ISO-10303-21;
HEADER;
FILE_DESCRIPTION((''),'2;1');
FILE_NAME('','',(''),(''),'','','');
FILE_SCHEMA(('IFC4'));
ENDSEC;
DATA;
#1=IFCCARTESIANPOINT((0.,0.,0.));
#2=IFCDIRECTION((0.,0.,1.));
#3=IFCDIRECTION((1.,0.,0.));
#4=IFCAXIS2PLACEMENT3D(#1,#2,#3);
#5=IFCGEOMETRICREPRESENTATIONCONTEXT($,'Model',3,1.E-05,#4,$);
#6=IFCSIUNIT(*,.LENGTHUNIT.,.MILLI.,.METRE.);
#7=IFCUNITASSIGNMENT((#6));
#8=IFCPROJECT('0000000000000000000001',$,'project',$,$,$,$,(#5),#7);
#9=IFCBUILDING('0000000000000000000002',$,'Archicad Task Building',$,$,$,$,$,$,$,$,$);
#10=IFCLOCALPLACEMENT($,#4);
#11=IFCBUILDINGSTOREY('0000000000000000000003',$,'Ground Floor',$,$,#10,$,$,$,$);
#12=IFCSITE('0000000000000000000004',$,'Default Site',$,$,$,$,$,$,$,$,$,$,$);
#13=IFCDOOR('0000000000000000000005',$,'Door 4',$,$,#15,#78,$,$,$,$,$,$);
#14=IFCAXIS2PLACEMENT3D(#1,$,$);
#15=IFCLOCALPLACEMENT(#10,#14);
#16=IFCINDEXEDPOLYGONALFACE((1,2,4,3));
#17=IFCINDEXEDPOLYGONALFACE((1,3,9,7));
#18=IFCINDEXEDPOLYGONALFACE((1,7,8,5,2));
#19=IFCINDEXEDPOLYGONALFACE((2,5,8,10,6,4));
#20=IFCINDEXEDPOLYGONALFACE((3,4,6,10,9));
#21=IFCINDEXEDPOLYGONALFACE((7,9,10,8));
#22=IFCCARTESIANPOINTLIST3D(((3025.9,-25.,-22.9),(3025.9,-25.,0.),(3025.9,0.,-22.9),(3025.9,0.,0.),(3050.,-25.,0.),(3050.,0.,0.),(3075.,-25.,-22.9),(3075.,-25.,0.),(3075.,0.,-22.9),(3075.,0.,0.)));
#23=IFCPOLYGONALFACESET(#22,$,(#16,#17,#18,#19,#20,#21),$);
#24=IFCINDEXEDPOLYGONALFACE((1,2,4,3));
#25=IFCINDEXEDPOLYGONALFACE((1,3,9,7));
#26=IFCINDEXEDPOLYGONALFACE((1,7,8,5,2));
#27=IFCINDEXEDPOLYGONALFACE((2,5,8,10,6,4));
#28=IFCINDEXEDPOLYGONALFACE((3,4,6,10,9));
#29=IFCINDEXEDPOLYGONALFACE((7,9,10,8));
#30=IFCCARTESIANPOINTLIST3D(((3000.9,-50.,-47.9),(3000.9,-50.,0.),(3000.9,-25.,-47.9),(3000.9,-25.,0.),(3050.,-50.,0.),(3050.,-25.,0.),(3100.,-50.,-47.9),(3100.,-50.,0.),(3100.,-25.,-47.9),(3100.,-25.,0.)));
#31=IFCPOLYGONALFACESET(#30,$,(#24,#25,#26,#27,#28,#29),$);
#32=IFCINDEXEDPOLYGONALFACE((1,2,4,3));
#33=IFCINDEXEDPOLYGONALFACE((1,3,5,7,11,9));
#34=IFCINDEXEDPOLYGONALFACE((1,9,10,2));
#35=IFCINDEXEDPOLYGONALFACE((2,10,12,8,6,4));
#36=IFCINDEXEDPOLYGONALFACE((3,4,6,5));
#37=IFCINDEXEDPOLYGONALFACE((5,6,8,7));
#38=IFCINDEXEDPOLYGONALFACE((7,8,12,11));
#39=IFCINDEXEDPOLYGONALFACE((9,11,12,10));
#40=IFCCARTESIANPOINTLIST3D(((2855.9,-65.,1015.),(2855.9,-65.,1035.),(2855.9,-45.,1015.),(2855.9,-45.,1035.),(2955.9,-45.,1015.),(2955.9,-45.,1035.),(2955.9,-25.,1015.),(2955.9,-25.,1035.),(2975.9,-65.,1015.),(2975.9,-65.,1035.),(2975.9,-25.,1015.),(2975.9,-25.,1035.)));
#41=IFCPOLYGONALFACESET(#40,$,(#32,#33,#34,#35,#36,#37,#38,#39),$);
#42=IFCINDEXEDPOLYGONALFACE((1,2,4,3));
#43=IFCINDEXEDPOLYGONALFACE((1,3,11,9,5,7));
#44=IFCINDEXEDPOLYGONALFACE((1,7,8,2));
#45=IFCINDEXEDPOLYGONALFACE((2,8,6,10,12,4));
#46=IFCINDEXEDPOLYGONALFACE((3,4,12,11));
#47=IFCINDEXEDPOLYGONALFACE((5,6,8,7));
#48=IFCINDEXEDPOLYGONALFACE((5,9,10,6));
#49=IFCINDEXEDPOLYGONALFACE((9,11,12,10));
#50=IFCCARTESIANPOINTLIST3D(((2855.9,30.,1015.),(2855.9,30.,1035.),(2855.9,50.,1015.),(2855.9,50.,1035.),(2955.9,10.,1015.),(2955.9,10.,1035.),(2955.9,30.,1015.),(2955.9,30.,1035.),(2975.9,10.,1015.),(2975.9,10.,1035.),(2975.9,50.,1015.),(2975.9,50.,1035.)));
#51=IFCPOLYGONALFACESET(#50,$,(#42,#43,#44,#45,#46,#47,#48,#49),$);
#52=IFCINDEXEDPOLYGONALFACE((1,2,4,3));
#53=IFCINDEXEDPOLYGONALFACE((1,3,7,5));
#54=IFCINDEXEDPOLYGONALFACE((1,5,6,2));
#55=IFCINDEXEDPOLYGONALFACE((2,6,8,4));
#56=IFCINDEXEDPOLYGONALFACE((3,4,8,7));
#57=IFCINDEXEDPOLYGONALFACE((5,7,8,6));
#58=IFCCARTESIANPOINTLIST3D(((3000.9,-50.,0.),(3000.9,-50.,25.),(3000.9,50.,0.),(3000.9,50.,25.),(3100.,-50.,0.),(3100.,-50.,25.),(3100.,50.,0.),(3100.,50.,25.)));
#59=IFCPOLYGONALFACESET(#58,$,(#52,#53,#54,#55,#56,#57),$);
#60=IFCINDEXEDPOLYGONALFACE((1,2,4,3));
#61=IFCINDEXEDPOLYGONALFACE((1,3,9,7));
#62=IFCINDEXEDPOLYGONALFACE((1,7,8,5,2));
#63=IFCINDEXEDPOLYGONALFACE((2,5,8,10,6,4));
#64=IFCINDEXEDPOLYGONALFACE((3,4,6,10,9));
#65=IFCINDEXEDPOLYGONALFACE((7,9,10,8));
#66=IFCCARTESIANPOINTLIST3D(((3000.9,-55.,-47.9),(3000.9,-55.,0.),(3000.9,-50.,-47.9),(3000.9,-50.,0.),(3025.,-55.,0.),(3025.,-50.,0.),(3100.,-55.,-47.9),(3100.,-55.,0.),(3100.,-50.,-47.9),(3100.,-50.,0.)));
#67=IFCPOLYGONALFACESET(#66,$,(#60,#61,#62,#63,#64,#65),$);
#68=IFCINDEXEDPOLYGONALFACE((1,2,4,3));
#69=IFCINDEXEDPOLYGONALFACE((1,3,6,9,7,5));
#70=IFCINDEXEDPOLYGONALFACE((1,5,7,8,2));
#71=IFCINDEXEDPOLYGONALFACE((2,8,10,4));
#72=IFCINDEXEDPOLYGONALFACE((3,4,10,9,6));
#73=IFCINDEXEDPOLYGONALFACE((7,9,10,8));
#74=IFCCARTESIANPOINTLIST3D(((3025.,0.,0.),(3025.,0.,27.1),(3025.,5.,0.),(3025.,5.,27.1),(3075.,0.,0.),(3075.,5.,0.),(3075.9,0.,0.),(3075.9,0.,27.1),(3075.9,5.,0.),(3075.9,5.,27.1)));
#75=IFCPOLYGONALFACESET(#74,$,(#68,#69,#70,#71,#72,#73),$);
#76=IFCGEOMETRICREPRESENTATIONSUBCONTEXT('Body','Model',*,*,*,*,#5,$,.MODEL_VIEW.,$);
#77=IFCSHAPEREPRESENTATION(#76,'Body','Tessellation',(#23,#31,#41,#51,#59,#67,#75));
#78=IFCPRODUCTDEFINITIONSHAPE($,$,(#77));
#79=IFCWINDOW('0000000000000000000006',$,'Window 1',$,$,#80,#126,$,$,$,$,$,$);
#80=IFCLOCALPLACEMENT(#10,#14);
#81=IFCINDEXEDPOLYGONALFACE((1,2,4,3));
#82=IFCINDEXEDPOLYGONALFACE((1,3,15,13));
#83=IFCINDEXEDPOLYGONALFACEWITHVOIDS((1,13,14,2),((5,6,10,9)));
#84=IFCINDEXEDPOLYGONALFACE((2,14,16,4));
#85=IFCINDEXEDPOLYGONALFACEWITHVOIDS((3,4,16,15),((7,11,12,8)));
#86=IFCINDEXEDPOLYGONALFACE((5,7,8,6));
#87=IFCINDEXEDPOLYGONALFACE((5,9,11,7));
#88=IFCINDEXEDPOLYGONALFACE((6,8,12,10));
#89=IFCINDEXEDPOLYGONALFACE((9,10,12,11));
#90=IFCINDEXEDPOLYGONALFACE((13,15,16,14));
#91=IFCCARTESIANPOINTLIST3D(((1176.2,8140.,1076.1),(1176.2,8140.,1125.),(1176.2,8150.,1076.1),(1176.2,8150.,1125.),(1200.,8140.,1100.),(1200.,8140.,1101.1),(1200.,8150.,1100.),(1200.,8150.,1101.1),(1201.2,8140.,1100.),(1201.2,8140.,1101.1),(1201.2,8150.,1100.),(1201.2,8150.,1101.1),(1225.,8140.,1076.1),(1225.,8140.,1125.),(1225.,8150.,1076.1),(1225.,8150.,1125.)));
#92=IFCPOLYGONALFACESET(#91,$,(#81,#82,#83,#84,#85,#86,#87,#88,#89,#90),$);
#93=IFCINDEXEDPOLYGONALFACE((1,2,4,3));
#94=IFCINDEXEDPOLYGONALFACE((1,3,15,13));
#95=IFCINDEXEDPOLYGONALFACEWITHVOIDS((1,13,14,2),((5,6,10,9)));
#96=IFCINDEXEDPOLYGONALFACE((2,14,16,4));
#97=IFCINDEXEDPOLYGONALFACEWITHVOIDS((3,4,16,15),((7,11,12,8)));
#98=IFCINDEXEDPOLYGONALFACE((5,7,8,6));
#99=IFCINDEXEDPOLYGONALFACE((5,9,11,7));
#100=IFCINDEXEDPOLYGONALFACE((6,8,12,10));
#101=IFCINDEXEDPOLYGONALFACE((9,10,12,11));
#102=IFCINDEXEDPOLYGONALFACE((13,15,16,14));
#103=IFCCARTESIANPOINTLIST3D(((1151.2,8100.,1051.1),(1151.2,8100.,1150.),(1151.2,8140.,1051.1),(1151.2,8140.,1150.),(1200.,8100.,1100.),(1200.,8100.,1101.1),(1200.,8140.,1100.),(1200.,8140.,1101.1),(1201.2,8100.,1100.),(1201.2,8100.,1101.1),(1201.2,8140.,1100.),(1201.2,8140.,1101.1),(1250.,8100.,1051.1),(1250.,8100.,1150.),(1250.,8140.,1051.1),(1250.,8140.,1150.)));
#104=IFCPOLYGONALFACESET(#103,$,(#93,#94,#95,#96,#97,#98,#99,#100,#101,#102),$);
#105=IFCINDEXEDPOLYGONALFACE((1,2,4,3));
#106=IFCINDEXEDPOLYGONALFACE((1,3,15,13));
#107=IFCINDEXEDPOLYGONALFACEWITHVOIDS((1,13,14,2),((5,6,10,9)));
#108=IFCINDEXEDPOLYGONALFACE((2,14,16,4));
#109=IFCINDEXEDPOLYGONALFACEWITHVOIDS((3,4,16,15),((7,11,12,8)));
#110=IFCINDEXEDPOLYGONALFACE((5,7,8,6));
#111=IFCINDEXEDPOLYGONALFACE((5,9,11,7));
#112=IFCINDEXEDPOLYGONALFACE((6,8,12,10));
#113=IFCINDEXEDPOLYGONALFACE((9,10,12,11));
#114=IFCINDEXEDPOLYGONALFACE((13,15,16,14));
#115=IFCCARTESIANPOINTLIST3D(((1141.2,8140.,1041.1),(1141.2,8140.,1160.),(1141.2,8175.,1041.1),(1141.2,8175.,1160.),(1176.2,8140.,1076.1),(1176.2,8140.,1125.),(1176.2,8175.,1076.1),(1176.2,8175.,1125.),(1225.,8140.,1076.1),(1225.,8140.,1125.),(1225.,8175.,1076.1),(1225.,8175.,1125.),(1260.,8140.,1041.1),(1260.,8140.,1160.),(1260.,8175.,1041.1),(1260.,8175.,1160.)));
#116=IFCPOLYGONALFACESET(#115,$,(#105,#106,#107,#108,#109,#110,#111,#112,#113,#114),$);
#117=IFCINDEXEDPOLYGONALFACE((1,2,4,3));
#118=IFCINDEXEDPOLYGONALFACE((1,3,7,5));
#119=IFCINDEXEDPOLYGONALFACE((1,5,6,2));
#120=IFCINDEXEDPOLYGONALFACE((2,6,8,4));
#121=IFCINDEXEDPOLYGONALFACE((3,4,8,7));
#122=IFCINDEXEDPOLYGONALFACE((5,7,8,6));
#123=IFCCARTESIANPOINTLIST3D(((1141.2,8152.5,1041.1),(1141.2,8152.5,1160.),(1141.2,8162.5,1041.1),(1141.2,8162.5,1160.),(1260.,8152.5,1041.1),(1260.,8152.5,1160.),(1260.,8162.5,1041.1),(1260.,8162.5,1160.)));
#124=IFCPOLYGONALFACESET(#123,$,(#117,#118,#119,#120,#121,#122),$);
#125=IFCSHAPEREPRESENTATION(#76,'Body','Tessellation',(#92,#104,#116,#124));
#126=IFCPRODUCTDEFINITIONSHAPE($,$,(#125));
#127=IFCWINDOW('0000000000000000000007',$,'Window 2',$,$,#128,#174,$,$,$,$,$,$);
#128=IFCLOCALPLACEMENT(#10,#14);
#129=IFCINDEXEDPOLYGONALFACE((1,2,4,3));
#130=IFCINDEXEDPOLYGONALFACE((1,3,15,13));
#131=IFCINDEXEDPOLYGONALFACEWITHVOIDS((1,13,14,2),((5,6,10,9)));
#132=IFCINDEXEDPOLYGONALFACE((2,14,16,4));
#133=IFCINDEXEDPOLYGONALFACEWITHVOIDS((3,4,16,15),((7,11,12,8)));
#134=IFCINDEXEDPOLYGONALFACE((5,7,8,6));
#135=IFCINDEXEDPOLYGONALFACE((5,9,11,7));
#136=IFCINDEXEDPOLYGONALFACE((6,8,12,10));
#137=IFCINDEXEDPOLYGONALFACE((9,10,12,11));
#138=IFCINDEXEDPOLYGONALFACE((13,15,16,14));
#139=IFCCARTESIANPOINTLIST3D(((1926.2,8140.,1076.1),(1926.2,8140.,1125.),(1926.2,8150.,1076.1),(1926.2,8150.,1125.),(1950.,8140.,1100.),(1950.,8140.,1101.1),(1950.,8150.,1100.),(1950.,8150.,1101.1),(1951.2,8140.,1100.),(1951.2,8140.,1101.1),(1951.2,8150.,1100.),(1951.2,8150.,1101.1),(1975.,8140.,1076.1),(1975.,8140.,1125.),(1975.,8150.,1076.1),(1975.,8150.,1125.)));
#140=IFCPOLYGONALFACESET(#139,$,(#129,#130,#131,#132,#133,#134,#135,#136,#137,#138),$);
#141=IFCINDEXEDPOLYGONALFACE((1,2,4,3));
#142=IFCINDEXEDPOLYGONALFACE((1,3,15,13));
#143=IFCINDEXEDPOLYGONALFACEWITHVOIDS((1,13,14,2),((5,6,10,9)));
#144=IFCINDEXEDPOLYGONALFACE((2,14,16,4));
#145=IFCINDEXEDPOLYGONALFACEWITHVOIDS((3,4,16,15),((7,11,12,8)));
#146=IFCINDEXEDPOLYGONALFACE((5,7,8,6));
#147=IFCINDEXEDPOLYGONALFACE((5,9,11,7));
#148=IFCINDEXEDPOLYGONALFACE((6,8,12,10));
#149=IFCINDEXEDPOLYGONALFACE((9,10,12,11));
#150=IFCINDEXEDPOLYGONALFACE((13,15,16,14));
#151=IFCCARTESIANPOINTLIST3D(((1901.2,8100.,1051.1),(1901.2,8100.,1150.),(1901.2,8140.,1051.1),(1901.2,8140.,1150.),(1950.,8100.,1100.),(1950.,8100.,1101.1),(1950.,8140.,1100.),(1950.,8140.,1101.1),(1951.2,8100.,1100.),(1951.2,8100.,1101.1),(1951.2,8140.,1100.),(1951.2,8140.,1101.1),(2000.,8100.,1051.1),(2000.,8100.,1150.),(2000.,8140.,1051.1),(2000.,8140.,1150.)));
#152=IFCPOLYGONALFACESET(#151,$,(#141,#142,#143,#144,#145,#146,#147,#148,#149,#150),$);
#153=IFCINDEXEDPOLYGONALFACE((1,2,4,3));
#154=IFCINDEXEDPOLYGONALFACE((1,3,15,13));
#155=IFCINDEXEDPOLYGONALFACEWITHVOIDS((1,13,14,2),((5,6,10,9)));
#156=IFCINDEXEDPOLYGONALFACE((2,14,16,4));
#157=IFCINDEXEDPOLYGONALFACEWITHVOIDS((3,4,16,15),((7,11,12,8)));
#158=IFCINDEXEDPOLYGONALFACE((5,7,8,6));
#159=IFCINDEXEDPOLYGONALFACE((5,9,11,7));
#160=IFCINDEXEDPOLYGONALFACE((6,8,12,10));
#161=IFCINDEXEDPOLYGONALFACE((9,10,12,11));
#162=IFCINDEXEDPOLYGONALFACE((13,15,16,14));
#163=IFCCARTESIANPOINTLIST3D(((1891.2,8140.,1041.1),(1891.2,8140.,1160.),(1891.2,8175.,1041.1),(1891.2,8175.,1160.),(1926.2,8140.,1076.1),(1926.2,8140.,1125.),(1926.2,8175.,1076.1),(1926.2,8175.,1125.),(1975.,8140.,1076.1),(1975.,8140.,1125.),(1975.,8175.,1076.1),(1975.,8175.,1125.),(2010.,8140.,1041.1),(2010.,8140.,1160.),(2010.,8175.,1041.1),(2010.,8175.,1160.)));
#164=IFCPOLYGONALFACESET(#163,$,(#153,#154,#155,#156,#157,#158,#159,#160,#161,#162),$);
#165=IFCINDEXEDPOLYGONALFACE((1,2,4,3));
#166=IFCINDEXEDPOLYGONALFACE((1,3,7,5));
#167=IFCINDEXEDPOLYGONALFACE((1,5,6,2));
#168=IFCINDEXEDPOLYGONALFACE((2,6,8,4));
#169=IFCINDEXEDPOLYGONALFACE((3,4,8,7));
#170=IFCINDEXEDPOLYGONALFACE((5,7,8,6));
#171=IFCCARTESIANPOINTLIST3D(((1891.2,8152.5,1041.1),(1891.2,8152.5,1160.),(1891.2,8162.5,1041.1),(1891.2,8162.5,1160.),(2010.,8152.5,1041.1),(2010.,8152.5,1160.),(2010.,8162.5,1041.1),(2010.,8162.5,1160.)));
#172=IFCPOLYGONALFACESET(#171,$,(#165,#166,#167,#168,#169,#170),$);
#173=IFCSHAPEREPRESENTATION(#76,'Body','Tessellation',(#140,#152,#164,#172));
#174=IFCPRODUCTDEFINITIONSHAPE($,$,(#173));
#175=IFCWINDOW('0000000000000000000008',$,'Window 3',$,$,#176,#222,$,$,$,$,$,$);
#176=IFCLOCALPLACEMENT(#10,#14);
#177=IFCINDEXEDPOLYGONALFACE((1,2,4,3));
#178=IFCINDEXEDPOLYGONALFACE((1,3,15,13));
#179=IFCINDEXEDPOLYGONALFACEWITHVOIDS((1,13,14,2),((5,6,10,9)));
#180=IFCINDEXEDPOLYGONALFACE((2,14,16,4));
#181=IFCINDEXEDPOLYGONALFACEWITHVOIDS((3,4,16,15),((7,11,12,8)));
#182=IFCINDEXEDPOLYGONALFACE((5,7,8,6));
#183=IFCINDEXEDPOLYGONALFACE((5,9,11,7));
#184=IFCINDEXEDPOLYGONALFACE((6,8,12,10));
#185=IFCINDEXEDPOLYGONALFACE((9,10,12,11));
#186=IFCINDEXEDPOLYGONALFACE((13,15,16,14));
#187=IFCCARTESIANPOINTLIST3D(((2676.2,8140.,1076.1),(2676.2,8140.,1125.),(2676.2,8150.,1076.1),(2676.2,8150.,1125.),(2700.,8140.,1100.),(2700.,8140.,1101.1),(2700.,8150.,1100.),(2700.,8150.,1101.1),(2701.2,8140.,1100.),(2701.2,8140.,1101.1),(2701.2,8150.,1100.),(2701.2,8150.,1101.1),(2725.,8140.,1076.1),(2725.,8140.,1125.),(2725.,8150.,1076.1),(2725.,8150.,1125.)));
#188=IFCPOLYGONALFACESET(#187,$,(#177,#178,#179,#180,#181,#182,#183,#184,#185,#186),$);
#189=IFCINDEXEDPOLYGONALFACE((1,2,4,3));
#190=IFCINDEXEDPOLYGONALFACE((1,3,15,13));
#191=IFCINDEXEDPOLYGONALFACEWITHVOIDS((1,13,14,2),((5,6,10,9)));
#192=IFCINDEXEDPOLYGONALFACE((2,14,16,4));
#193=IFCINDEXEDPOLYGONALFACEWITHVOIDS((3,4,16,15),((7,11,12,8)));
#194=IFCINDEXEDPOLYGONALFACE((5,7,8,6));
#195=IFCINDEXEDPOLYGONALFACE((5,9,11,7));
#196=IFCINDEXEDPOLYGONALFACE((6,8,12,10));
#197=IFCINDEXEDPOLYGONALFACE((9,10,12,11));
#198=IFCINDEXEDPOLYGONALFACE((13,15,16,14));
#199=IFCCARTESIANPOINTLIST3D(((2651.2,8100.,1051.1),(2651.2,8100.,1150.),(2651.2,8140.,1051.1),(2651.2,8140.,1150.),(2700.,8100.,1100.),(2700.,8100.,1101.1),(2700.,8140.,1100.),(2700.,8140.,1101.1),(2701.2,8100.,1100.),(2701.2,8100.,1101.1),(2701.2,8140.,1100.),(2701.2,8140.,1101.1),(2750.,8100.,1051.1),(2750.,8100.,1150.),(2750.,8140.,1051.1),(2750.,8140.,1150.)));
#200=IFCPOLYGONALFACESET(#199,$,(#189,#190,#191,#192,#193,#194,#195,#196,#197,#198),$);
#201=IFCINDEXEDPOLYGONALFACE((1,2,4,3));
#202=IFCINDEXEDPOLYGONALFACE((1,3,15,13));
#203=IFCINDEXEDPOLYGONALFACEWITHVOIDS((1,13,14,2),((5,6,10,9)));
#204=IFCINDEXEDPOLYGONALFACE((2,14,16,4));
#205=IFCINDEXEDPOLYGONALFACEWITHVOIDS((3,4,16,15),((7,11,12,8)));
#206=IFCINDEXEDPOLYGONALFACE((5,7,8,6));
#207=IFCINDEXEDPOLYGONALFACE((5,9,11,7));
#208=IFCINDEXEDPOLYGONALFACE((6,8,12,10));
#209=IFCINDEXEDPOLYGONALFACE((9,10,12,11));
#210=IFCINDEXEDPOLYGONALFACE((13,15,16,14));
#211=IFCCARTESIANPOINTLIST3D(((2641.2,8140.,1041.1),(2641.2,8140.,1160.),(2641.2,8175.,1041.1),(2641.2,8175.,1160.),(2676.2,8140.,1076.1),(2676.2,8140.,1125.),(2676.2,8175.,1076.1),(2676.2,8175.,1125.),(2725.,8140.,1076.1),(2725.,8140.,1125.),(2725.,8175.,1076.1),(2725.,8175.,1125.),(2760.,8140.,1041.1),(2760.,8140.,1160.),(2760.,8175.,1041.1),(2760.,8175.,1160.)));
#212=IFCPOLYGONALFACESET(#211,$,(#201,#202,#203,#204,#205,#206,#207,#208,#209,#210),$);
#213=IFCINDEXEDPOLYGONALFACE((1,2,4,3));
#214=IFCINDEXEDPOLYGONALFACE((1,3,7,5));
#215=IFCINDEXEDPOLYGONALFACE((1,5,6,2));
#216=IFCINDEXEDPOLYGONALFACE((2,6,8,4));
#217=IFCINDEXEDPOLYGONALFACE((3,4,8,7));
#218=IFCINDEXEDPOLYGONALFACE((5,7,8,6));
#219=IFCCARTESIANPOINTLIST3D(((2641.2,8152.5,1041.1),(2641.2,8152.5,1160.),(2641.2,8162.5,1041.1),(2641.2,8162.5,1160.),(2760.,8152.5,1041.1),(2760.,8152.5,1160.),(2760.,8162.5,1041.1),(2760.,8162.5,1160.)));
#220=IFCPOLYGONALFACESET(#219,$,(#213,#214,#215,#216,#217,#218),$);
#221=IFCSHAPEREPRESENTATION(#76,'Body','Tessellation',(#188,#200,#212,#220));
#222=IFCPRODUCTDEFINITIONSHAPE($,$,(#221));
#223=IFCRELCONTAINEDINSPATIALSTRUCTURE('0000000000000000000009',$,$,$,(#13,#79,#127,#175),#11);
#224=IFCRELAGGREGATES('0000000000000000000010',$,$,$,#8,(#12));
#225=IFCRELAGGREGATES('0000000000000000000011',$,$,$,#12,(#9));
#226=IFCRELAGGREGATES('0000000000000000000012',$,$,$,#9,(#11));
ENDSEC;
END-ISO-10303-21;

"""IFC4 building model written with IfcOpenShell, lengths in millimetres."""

from ifc_helpers import new_model, si_unit, frame, origin_with_axes, place, context, subcontext, project, spatial, line, indexed_curve, outline, extrude, element, save


model = new_model("IFC4")

# Units and contexts
model_context = context("Model", 3, precision=1e-05, world=origin_with_axes())
body_context = subcontext(model_context, "Body", "Model", "MODEL_VIEW")
ifc_project = project(units=[si_unit("LENGTHUNIT", "METRE", prefix="MILLI")], contexts=[model_context])

# Site, building, storey
site = spatial("IfcSite", under=ifc_project, Name="Default Site")
building = spatial("IfcBuilding", under=site, Name="Archicad Task Building")
storey_placement = place(None, origin_with_axes())
storey = spatial("IfcBuildingStorey", under=building, at=storey_placement, Name="Ground Floor")

# Door
door_1_placement = place(storey_placement, frame((3050.0, -50.0, 0.0), z_axis=(0.0, 0.0, 1.0), x_axis=(1.0, 0.0, 0.0)))
element("IfcDoor", 1, at=door_1_placement, inside=storey, Name="Door 4", context=body_context, shape_type="SweptSolid", body=[
    extrude(outline(indexed_curve([(0.0, 0.0), (0.0, 2.1), (0.9, 2.1), (0.9, 0.0), (-24.1, 0.0), (-24.1, -22.9), (25.0, -22.9), (25.0, 0.0)], segments=[line(1, 2, 3, 4, 5, 6, 7, 8, 1)])), frame((0.0, 25.0, 0.0), z_axis=(0.0, -1.0, 0.0), x_axis=(1.0, 0.0, 0.0)), (0.0, 0.0, -1.0), 25.0),
    extrude(outline(indexed_curve([(0.0, 0.0), (0.0, 2.1), (0.9, 2.1), (0.9, 0.0), (-49.1, 0.0), (-49.1, -47.9), (50.0, -47.9), (50.0, 0.0)], segments=[line(1, 2, 3, 4, 5, 6, 7, 8, 1)])), frame((0.0, 0.0, 0.0), z_axis=(0.0, -1.0, 0.0), x_axis=(1.0, 0.0, 0.0)), (0.0, 0.0, -1.0), 25.0),
    extrude(outline(indexed_curve([(0.0, 0.0), (-49.1, 0.0), (-49.1, 35.0), (0.0, 35.0)], segments=[line(1, 2, 3, 4, 1)])), frame((25.0, 25.0, 25.0), z_axis=(0.0, 0.0, 1.0), x_axis=(1.0, 0.0, 0.0)), (0.0, 0.0, 1.0), -47.9),
    extrude(outline(indexed_curve([(0.0, 0.0), (0.0, -40.0), (-120.0, -40.0), (-120.0, -20.0), (-20.0, -20.0), (-20.0, 0.0)], segments=[line(1, 2, 3, 4, 5, 6, 1)])), frame((-74.1, 25.0, 1015.0), z_axis=(0.0, 0.0, 1.0), x_axis=(1.0, 0.0, 0.0)), (0.0, 0.0, 1.0), 20.0),
    extrude(outline(indexed_curve([(0.0, 0.0), (0.0, 40.0), (-120.0, 40.0), (-120.0, 20.0), (-20.0, 20.0), (-20.0, 0.0)], segments=[line(1, 2, 3, 4, 5, 6, 1)])), frame((-74.1, 60.0, 1015.0), z_axis=(0.0, 0.0, 1.0), x_axis=(1.0, 0.0, 0.0)), (0.0, 0.0, 1.0), 20.0),
    extrude(outline(indexed_curve([(0.0, 0.0), (-99.1, 0.0), (-99.1, 100.0), (0.0, 100.0)], segments=[line(1, 2, 3, 4, 1)])), frame((50.0, 0.0, 0.0), z_axis=(0.0, 0.0, 1.0), x_axis=(1.0, 0.0, 0.0)), (0.0, 0.0, 1.0), 25.0),
    extrude(outline(indexed_curve([(0.0, 0.0), (0.0, 27.1), (50.9, 27.1), (50.9, 0.0), (-24.1, 0.0), (-24.1, -47.9), (75.0, -47.9), (75.0, 0.0)], segments=[line(1, 2, 3, 4, 5, 6, 7, 8, 1)])), frame((-25.0, -5.0, 0.0), z_axis=(0.0, -1.0, 0.0), x_axis=(1.0, 0.0, 0.0)), (0.0, 0.0, -1.0), 5.0),
    extrude(outline(indexed_curve([(0.0, 0.0), (0.0, 27.1), (50.9, 27.1), (50.9, 0.0), (0.9, 0.0), (0.9, -22.9), (50.0, -22.9), (50.0, 0.0)], segments=[line(1, 2, 3, 4, 5, 6, 7, 8, 1)])), frame((-25.0, 50.0, 0.0), z_axis=(0.0, -1.0, 0.0), x_axis=(1.0, 0.0, 0.0)), (0.0, 0.0, -1.0), 5.0),
])

# Windows
for number, where, z_axis, x_axis, name in (
    (2, (1200.0, 8050.0, 1100.0), (0.0, 0.0, 1.0), (1.0, 0.0, 0.0), "Window 1"),
    (3, (1950.0, 8050.0, 1100.0), (0.0, 0.0, 1.0), (1.0, 0.0, 0.0), "Window 2"),
    (4, (2700.0, 8050.0, 1100.0), (0.0, 0.0, 1.0), (1.0, 0.0, 0.0), "Window 3"),
):
    element("IfcWindow", number, at=place(storey_placement, frame(where, z_axis=z_axis, x_axis=x_axis)), inside=storey, Name=name, context=body_context, shape_type="SweptSolid", body=[
        extrude(outline(indexed_curve([(0.0, 0.0), (1.2, 0.0), (1.2, 1.1), (0.0, 1.1)], segments=[line(1, 2, 3, 4, 1)]), holes=[indexed_curve([(25.0, 25.0), (-23.8, 25.0), (-23.8, -23.9), (25.0, -23.9)], segments=[line(1, 2, 3, 4, 1)])]), frame((0.0, 90.0, 0.0), z_axis=(0.0, -1.0, 0.0), x_axis=(1.0, 0.0, 0.0)), (0.0, 0.0, -1.0), 10.0),
        extrude(outline(indexed_curve([(0.0, 0.0), (1.2, 0.0), (1.2, 1.1), (0.0, 1.1)], segments=[line(1, 2, 3, 4, 1)]), holes=[indexed_curve([(50.0, 50.0), (-48.8, 50.0), (-48.8, -48.9), (50.0, -48.9)], segments=[line(1, 2, 3, 4, 1)])]), frame((0.0, 50.0, 0.0), z_axis=(0.0, -1.0, 0.0), x_axis=(1.0, 0.0, 0.0)), (0.0, 0.0, -1.0), 40.0),
        extrude(outline(indexed_curve([(0.0, 0.0), (-48.8, 0.0), (-48.8, -48.9), (0.0, -48.9)], segments=[line(1, 2, 3, 4, 1)]), holes=[indexed_curve([(35.0, 35.0), (-83.8, 35.0), (-83.8, -83.9), (35.0, -83.9)], segments=[line(1, 2, 3, 4, 1)])]), frame((25.0, 90.0, 25.0), z_axis=(0.0, -1.0, 0.0), x_axis=(1.0, 0.0, 0.0)), (0.0, 0.0, -1.0), 35.0),
        extrude(outline(indexed_curve([(35.0, 35.0), (-83.8, 35.0), (-83.8, -83.9), (35.0, -83.9)], segments=[line(1, 2, 3, 4, 1)])), frame((25.0, 102.5, 25.0), z_axis=(0.0, -1.0, 0.0), x_axis=(1.0, 0.0, 0.0)), (0.0, 0.0, -1.0), 10.0),
    ])

save(model, "model.ifc")
